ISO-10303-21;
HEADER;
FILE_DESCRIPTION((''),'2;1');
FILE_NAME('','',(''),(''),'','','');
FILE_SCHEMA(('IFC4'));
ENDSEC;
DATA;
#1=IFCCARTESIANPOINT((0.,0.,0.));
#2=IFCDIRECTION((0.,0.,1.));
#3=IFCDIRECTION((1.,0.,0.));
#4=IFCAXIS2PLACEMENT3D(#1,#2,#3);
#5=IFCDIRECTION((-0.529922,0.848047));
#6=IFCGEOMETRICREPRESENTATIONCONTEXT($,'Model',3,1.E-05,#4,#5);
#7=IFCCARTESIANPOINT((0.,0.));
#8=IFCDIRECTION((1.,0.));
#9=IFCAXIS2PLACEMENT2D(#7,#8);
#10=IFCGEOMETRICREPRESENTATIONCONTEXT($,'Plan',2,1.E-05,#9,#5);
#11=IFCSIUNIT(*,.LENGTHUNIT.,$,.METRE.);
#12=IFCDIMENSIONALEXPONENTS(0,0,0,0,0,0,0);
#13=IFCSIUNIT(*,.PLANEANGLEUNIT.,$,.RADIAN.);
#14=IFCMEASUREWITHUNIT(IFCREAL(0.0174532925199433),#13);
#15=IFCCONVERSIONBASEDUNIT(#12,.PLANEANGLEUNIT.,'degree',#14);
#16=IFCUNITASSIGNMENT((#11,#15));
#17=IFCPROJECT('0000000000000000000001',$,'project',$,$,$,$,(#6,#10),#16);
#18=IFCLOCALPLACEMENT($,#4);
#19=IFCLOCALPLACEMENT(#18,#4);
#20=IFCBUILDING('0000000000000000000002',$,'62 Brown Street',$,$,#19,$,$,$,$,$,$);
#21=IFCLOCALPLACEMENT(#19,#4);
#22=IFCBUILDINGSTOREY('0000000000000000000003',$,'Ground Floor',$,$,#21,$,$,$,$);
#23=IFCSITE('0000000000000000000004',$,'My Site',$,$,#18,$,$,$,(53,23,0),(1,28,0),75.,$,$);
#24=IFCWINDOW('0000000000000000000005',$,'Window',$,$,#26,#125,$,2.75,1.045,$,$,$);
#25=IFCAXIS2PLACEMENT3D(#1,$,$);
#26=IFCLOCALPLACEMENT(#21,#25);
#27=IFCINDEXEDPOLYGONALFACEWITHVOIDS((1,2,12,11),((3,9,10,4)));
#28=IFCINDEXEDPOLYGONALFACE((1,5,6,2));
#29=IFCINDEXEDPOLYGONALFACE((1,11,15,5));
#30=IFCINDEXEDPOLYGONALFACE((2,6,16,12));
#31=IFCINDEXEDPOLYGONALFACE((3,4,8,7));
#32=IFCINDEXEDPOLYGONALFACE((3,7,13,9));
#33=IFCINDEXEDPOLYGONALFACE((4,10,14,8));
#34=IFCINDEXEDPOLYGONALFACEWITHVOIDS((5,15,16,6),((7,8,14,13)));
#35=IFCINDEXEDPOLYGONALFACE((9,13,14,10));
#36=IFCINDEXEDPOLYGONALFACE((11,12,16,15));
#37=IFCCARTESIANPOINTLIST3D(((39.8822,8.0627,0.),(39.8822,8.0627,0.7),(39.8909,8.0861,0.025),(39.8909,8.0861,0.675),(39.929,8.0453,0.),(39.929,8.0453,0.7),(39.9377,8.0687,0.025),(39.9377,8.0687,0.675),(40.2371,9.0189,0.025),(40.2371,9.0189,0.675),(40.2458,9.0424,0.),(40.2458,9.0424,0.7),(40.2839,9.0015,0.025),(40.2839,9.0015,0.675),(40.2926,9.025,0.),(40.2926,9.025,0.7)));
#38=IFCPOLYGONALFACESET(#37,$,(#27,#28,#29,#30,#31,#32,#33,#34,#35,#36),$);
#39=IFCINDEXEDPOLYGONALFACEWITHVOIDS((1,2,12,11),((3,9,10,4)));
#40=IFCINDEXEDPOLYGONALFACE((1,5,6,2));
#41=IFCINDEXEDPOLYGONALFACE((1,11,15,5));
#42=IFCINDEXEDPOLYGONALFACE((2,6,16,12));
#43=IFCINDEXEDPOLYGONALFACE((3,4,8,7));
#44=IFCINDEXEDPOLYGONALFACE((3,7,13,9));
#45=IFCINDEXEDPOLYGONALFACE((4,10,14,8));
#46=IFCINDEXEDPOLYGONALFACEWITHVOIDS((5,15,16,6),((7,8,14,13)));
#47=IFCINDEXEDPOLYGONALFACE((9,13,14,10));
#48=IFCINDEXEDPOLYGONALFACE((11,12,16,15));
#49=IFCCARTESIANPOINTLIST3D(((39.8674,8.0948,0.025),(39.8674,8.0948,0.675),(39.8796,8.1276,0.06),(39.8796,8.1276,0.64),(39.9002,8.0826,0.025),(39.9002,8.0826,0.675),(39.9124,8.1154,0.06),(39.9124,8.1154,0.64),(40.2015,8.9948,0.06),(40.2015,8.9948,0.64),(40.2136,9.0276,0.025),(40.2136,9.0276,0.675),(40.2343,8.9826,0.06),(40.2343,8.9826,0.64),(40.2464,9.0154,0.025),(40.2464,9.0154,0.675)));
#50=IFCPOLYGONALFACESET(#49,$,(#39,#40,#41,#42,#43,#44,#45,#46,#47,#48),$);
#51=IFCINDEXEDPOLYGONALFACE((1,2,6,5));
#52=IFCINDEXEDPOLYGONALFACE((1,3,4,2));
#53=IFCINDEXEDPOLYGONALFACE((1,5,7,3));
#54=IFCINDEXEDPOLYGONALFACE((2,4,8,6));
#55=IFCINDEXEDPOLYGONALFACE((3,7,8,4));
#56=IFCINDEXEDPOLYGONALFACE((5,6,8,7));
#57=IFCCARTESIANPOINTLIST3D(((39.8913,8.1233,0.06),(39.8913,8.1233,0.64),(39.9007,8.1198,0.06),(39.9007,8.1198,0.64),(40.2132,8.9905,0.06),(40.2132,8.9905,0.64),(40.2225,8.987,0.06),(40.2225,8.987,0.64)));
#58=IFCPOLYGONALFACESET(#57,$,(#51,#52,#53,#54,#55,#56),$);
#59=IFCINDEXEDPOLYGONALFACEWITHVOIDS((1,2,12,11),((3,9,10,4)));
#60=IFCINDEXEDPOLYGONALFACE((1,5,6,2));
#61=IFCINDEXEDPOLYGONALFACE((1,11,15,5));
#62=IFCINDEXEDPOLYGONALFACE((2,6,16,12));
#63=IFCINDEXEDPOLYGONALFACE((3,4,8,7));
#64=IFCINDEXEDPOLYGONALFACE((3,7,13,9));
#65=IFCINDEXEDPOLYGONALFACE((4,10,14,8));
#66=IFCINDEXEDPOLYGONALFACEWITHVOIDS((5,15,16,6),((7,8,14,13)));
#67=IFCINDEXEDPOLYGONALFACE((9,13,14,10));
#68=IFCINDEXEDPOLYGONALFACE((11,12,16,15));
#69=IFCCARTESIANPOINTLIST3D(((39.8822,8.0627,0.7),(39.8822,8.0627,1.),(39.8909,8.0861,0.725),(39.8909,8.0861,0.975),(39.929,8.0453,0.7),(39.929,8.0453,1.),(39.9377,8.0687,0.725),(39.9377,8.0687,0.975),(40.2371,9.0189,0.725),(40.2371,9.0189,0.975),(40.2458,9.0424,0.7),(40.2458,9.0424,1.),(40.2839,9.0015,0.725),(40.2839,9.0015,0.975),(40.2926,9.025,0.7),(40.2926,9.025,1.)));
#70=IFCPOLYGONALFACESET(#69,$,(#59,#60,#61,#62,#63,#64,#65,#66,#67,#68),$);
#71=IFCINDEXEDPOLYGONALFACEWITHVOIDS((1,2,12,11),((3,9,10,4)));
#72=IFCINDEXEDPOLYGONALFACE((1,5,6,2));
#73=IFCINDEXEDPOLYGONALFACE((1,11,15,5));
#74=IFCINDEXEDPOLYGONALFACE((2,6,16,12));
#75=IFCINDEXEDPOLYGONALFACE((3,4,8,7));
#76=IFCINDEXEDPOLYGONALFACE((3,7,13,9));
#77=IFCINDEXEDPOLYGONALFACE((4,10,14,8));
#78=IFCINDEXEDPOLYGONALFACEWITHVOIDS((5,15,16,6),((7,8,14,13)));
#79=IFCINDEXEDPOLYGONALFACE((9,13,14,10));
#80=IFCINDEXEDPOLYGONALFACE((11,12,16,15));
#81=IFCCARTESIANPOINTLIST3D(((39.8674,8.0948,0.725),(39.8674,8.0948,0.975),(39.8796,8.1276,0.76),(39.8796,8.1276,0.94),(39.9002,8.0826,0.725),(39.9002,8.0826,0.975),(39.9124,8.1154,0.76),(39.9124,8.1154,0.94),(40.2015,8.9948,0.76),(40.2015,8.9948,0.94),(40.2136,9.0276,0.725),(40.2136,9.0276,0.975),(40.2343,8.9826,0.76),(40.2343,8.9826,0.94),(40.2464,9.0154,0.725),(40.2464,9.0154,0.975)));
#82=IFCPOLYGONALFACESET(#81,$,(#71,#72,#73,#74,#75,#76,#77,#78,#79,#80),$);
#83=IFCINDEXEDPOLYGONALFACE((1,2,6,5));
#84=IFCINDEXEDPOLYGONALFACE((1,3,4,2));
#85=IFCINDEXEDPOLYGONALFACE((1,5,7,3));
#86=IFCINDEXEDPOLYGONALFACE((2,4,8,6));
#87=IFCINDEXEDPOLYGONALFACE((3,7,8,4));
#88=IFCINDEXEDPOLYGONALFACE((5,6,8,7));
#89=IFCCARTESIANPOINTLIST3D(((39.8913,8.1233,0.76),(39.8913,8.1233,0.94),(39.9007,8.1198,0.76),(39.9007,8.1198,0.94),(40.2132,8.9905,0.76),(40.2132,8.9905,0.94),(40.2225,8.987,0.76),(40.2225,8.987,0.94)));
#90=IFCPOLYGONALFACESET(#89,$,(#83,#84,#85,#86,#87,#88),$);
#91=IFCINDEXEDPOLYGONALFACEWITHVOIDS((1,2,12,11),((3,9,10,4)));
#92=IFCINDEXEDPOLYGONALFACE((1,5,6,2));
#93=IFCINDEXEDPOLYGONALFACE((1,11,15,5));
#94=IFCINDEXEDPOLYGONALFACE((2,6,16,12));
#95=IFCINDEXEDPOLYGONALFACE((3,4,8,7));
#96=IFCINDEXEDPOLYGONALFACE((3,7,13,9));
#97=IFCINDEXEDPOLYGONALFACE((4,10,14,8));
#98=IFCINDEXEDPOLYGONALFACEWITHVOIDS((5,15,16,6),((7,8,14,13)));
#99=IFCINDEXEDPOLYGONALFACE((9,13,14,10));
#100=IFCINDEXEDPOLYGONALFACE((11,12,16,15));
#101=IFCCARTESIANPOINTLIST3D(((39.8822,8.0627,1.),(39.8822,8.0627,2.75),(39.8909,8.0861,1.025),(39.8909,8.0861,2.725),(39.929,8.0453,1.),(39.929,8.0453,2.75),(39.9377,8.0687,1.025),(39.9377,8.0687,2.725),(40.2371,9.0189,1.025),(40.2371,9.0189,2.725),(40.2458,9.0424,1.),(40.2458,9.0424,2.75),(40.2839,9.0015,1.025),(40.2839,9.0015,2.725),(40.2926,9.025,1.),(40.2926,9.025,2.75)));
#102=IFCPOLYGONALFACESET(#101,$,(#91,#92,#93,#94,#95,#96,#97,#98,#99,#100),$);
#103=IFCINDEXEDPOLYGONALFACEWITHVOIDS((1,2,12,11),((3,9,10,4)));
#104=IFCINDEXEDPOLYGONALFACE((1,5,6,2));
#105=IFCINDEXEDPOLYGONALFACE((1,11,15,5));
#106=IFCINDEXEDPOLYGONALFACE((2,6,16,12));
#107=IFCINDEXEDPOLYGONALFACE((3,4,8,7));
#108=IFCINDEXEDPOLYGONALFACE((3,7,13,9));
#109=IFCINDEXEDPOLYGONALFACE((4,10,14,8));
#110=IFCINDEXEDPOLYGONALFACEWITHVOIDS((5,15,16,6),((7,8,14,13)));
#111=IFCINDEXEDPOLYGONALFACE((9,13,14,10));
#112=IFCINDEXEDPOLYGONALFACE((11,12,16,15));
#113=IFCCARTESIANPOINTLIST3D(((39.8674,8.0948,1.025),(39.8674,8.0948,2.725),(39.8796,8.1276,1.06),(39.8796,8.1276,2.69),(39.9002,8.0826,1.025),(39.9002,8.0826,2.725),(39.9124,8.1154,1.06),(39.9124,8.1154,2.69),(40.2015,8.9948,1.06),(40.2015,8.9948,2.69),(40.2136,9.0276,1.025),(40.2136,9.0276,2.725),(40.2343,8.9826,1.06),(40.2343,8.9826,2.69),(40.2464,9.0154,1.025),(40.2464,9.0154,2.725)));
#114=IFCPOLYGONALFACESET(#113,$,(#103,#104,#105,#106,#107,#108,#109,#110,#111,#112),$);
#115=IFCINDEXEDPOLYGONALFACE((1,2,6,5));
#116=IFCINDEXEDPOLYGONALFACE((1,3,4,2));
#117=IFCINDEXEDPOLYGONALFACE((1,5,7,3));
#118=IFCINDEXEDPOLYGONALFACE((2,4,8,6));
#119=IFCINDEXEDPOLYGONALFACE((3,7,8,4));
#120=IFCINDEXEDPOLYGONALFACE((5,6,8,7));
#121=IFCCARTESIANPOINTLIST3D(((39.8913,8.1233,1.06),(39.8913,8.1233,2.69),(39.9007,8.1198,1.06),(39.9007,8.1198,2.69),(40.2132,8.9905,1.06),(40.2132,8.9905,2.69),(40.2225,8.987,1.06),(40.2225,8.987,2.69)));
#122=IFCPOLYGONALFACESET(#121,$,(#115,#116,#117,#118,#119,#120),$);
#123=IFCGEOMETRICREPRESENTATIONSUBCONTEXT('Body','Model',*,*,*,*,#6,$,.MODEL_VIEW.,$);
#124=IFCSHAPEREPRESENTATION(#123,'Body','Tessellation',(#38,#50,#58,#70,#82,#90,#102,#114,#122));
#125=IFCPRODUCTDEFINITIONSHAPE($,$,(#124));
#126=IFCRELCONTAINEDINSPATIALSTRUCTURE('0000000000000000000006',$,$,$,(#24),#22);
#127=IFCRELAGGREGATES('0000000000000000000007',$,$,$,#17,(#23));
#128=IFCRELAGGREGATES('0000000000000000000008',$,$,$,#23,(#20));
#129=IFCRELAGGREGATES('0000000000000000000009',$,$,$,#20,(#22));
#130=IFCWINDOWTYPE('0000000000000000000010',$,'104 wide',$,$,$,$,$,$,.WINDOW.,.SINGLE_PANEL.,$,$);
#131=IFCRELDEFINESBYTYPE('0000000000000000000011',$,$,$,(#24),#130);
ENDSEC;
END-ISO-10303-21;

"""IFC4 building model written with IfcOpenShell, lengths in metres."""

from ifc_helpers import new_model, entity, si_unit, converted_unit, direction, frame, origin_with_axes, origin_2d_with_axis, place, context, subcontext, project, spatial, line, indexed_curve, outline, extrude, shape, source, transform, mapped, type_object, type_shapes, element, save


model = new_model("IFC4")

# Units and contexts
model_context = context("Model", 3, precision=1e-05, world=origin_with_axes(), true_north=direction((-0.529922, 0.848047)))
plan_context = context("Plan", 2, precision=1e-05, world=origin_2d_with_axis(), true_north=direction((-0.529922, 0.848047)))
body_context_1 = subcontext(model_context, "Body", "Model", "MODEL_VIEW")
body_context_2 = subcontext(plan_context, "Body", "Plan", "PLAN_VIEW")
ifc_project = project(units=[si_unit("LENGTHUNIT", "METRE"), converted_unit("PLANEANGLEUNIT", "degree", entity("IfcReal", 0.0174532925199433), si_unit("PLANEANGLEUNIT", "RADIAN"), dimensions=[0, 0, 0, 0, 0, 0, 0])], contexts=[model_context, plan_context])

# Site, building, storey
site_placement = place(None, origin_with_axes())
site = spatial("IfcSite", under=ifc_project, at=site_placement, Name="My Site", RefLatitude=(53, 23, 0), RefLongitude=(1, 28, 0), RefElevation=75.0)
building_placement = place(site_placement, origin_with_axes())
building = spatial("IfcBuilding", under=site, at=building_placement, Name="62 Brown Street")
storey_placement = place(building_placement, origin_with_axes())
storey = spatial("IfcBuildingStorey", under=building, at=storey_placement, Name="Ground Floor")

# Window
window_type_1 = type_object("IfcWindowType", Name="104 wide", PartitioningType="SINGLE_PANEL", PredefinedType="WINDOW")
shared_shape_1 = source(origin_with_axes(), body_context_1, "Body", "SweptSolid", [
    extrude(outline(indexed_curve([(0.0, 0.0), (1.045, 0.0), (1.045, 0.7), (0.0, 0.7)], segments=[line(1, 2, 3, 4, 1)]), holes=[indexed_curve([(0.025, 0.025), (1.02, 0.025), (1.02, 0.675), (0.025, 0.675)], segments=[line(1, 2, 3, 4, 1)])]), frame((0.0, 0.15, 0.0), z_axis=(0.0, -1.0, 0.0), x_axis=(1.0, 0.0, 0.0)), (0.0, 0.0, -1.0), 0.05),
    extrude(outline(indexed_curve([(0.0, 0.0), (0.995, 0.0), (0.995, 0.65), (0.0, 0.65)], segments=[line(1, 2, 3, 4, 1)]), holes=[indexed_curve([(0.035, 0.035), (0.96, 0.035), (0.96, 0.615), (0.035, 0.615)], segments=[line(1, 2, 3, 4, 1)])]), frame((0.025, 0.19, 0.025), z_axis=(0.0, -1.0, 0.0), x_axis=(1.0, 0.0, 0.0)), (0.0, 0.0, -1.0), 0.035),
    extrude(outline(indexed_curve([(0.035, 0.035), (0.96, 0.035), (0.96, 0.615), (0.035, 0.615)], segments=[line(1, 2, 3, 4, 1)])), frame((0.025, 0.2025, 0.025), z_axis=(0.0, -1.0, 0.0), x_axis=(1.0, 0.0, 0.0)), (0.0, 0.0, -1.0), 0.01),
    extrude(outline(indexed_curve([(0.0, 0.0), (1.045, 0.0), (1.045, 0.3), (0.0, 0.3)], segments=[line(1, 2, 3, 4, 1)]), holes=[indexed_curve([(0.025, 0.025), (1.02, 0.025), (1.02, 0.275), (0.025, 0.275)], segments=[line(1, 2, 3, 4, 1)])]), frame((0.0, 0.15, 0.7), z_axis=(0.0, -1.0, 0.0), x_axis=(1.0, 0.0, 0.0)), (0.0, 0.0, -1.0), 0.05),
    extrude(outline(indexed_curve([(0.0, 0.0), (0.995, 0.0), (0.995, 0.25), (0.0, 0.25)], segments=[line(1, 2, 3, 4, 1)]), holes=[indexed_curve([(0.035, 0.035), (0.96, 0.035), (0.96, 0.215), (0.035, 0.215)], segments=[line(1, 2, 3, 4, 1)])]), frame((0.025, 0.19, 0.725), z_axis=(0.0, -1.0, 0.0), x_axis=(1.0, 0.0, 0.0)), (0.0, 0.0, -1.0), 0.035),
    extrude(outline(indexed_curve([(0.035, 0.035), (0.96, 0.035), (0.96, 0.215), (0.035, 0.215)], segments=[line(1, 2, 3, 4, 1)])), frame((0.025, 0.2025, 0.725), z_axis=(0.0, -1.0, 0.0), x_axis=(1.0, 0.0, 0.0)), (0.0, 0.0, -1.0), 0.01),
    extrude(outline(indexed_curve([(0.0, 0.0), (1.045, 0.0), (1.045, 1.75), (0.0, 1.75)], segments=[line(1, 2, 3, 4, 1)]), holes=[indexed_curve([(0.025, 0.025), (1.02, 0.025), (1.02, 1.725), (0.025, 1.725)], segments=[line(1, 2, 3, 4, 1)])]), frame((0.0, 0.15, 1.0), z_axis=(0.0, -1.0, 0.0), x_axis=(1.0, 0.0, 0.0)), (0.0, 0.0, -1.0), 0.05),
    extrude(outline(indexed_curve([(0.0, 0.0), (0.995, 0.0), (0.995, 1.7), (0.0, 1.7)], segments=[line(1, 2, 3, 4, 1)]), holes=[indexed_curve([(0.035, 0.035), (0.96, 0.035), (0.96, 1.665), (0.035, 1.665)], segments=[line(1, 2, 3, 4, 1)])]), frame((0.025, 0.19, 1.025), z_axis=(0.0, -1.0, 0.0), x_axis=(1.0, 0.0, 0.0)), (0.0, 0.0, -1.0), 0.035),
    extrude(outline(indexed_curve([(0.035, 0.035), (0.96, 0.035), (0.96, 1.665), (0.035, 1.665)], segments=[line(1, 2, 3, 4, 1)])), frame((0.025, 0.2025, 1.025), z_axis=(0.0, -1.0, 0.0), x_axis=(1.0, 0.0, 0.0)), (0.0, 0.0, -1.0), 0.01),
])
shared_shape_2 = source(origin_with_axes(), body_context_2, "Body", "Curve2D", [
    entity("IfcIndexedPolyCurve", entity("IfcCartesianPointList2D", [[0.025, 0.15], [1.02, 0.15]])),
    entity("IfcIndexedPolyCurve", entity("IfcCartesianPointList2D", [[0.0, 0.2], [0.025, 0.2], [0.025, 0.15], [0.0, 0.15]]), [entity("IfcLineIndex", [1, 2, 3, 4, 1])]),
    entity("IfcIndexedPolyCurve", entity("IfcCartesianPointList2D", [[1.045, 0.2], [1.02, 0.2], [1.02, 0.15], [1.045, 0.15]]), [entity("IfcLineIndex", [1, 2, 3, 4, 1])]),
    entity("IfcIndexedPolyCurve", entity("IfcCartesianPointList2D", [[0.025, 0.19], [0.06, 0.19], [0.06, 0.225], [0.025, 0.225]]), [entity("IfcLineIndex", [1, 2, 3, 4, 1])]),
    entity("IfcIndexedPolyCurve", entity("IfcCartesianPointList2D", [[1.02, 0.19], [0.985, 0.19], [0.985, 0.225], [1.02, 0.225]]), [entity("IfcLineIndex", [1, 2, 3, 4, 1])]),
    entity("IfcIndexedPolyCurve", entity("IfcCartesianPointList2D", [[0.06, 0.19], [0.985, 0.19]])),
    entity("IfcIndexedPolyCurve", entity("IfcCartesianPointList2D", [[0.06, 0.225], [0.985, 0.225]])),
    entity("IfcIndexedPolyCurve", entity("IfcCartesianPointList2D", [[0.06, 0.2075], [0.985, 0.2075]])),
])
type_shapes(window_type_1, [shared_shape_1, shared_shape_2])
placement_1 = place(storey_placement, frame((39.024, 5.1755, 0.0), z_axis=(0.0, 0.0, 1.0), x_axis=(0.347944, 0.937515, 0.0)))
placement_2 = place(placement_1, frame((3.0054, 0.0, 0.0), z_axis=(0.0, 0.0, 1.0), x_axis=(1.0, 0.0, 0.0)))
window_1_placement = place(placement_2, frame((0.0, 0.0, 0.0), z_axis=(0.0, 0.0, 1.0), x_axis=(1.0, 0.0, 0.0)))
element("IfcWindow", 1, at=window_1_placement, inside=storey, type_object=window_type_1, Name="Window", OverallHeight=2.75, OverallWidth=1.045, shapes=[
    shape(body_context_1, "Body", "MappedRepresentation", [mapped(shared_shape_1, transform((0.0, 0.0, 0.0), x_axis=(1.0, 0.0, 0.0), y_axis=(0.0, 1.0, 0.0), z_axis=(0.0, 0.0, 1.0), scale=1.0))]),
    shape(body_context_2, "Body", "MappedRepresentation", [mapped(shared_shape_2, transform((0.0, 0.0, 0.0), x_axis=(1.0, 0.0, 0.0), y_axis=(0.0, 1.0, 0.0), z_axis=(0.0, 0.0, 1.0), scale=1.0))]),
])

save(model, "model.ifc")
